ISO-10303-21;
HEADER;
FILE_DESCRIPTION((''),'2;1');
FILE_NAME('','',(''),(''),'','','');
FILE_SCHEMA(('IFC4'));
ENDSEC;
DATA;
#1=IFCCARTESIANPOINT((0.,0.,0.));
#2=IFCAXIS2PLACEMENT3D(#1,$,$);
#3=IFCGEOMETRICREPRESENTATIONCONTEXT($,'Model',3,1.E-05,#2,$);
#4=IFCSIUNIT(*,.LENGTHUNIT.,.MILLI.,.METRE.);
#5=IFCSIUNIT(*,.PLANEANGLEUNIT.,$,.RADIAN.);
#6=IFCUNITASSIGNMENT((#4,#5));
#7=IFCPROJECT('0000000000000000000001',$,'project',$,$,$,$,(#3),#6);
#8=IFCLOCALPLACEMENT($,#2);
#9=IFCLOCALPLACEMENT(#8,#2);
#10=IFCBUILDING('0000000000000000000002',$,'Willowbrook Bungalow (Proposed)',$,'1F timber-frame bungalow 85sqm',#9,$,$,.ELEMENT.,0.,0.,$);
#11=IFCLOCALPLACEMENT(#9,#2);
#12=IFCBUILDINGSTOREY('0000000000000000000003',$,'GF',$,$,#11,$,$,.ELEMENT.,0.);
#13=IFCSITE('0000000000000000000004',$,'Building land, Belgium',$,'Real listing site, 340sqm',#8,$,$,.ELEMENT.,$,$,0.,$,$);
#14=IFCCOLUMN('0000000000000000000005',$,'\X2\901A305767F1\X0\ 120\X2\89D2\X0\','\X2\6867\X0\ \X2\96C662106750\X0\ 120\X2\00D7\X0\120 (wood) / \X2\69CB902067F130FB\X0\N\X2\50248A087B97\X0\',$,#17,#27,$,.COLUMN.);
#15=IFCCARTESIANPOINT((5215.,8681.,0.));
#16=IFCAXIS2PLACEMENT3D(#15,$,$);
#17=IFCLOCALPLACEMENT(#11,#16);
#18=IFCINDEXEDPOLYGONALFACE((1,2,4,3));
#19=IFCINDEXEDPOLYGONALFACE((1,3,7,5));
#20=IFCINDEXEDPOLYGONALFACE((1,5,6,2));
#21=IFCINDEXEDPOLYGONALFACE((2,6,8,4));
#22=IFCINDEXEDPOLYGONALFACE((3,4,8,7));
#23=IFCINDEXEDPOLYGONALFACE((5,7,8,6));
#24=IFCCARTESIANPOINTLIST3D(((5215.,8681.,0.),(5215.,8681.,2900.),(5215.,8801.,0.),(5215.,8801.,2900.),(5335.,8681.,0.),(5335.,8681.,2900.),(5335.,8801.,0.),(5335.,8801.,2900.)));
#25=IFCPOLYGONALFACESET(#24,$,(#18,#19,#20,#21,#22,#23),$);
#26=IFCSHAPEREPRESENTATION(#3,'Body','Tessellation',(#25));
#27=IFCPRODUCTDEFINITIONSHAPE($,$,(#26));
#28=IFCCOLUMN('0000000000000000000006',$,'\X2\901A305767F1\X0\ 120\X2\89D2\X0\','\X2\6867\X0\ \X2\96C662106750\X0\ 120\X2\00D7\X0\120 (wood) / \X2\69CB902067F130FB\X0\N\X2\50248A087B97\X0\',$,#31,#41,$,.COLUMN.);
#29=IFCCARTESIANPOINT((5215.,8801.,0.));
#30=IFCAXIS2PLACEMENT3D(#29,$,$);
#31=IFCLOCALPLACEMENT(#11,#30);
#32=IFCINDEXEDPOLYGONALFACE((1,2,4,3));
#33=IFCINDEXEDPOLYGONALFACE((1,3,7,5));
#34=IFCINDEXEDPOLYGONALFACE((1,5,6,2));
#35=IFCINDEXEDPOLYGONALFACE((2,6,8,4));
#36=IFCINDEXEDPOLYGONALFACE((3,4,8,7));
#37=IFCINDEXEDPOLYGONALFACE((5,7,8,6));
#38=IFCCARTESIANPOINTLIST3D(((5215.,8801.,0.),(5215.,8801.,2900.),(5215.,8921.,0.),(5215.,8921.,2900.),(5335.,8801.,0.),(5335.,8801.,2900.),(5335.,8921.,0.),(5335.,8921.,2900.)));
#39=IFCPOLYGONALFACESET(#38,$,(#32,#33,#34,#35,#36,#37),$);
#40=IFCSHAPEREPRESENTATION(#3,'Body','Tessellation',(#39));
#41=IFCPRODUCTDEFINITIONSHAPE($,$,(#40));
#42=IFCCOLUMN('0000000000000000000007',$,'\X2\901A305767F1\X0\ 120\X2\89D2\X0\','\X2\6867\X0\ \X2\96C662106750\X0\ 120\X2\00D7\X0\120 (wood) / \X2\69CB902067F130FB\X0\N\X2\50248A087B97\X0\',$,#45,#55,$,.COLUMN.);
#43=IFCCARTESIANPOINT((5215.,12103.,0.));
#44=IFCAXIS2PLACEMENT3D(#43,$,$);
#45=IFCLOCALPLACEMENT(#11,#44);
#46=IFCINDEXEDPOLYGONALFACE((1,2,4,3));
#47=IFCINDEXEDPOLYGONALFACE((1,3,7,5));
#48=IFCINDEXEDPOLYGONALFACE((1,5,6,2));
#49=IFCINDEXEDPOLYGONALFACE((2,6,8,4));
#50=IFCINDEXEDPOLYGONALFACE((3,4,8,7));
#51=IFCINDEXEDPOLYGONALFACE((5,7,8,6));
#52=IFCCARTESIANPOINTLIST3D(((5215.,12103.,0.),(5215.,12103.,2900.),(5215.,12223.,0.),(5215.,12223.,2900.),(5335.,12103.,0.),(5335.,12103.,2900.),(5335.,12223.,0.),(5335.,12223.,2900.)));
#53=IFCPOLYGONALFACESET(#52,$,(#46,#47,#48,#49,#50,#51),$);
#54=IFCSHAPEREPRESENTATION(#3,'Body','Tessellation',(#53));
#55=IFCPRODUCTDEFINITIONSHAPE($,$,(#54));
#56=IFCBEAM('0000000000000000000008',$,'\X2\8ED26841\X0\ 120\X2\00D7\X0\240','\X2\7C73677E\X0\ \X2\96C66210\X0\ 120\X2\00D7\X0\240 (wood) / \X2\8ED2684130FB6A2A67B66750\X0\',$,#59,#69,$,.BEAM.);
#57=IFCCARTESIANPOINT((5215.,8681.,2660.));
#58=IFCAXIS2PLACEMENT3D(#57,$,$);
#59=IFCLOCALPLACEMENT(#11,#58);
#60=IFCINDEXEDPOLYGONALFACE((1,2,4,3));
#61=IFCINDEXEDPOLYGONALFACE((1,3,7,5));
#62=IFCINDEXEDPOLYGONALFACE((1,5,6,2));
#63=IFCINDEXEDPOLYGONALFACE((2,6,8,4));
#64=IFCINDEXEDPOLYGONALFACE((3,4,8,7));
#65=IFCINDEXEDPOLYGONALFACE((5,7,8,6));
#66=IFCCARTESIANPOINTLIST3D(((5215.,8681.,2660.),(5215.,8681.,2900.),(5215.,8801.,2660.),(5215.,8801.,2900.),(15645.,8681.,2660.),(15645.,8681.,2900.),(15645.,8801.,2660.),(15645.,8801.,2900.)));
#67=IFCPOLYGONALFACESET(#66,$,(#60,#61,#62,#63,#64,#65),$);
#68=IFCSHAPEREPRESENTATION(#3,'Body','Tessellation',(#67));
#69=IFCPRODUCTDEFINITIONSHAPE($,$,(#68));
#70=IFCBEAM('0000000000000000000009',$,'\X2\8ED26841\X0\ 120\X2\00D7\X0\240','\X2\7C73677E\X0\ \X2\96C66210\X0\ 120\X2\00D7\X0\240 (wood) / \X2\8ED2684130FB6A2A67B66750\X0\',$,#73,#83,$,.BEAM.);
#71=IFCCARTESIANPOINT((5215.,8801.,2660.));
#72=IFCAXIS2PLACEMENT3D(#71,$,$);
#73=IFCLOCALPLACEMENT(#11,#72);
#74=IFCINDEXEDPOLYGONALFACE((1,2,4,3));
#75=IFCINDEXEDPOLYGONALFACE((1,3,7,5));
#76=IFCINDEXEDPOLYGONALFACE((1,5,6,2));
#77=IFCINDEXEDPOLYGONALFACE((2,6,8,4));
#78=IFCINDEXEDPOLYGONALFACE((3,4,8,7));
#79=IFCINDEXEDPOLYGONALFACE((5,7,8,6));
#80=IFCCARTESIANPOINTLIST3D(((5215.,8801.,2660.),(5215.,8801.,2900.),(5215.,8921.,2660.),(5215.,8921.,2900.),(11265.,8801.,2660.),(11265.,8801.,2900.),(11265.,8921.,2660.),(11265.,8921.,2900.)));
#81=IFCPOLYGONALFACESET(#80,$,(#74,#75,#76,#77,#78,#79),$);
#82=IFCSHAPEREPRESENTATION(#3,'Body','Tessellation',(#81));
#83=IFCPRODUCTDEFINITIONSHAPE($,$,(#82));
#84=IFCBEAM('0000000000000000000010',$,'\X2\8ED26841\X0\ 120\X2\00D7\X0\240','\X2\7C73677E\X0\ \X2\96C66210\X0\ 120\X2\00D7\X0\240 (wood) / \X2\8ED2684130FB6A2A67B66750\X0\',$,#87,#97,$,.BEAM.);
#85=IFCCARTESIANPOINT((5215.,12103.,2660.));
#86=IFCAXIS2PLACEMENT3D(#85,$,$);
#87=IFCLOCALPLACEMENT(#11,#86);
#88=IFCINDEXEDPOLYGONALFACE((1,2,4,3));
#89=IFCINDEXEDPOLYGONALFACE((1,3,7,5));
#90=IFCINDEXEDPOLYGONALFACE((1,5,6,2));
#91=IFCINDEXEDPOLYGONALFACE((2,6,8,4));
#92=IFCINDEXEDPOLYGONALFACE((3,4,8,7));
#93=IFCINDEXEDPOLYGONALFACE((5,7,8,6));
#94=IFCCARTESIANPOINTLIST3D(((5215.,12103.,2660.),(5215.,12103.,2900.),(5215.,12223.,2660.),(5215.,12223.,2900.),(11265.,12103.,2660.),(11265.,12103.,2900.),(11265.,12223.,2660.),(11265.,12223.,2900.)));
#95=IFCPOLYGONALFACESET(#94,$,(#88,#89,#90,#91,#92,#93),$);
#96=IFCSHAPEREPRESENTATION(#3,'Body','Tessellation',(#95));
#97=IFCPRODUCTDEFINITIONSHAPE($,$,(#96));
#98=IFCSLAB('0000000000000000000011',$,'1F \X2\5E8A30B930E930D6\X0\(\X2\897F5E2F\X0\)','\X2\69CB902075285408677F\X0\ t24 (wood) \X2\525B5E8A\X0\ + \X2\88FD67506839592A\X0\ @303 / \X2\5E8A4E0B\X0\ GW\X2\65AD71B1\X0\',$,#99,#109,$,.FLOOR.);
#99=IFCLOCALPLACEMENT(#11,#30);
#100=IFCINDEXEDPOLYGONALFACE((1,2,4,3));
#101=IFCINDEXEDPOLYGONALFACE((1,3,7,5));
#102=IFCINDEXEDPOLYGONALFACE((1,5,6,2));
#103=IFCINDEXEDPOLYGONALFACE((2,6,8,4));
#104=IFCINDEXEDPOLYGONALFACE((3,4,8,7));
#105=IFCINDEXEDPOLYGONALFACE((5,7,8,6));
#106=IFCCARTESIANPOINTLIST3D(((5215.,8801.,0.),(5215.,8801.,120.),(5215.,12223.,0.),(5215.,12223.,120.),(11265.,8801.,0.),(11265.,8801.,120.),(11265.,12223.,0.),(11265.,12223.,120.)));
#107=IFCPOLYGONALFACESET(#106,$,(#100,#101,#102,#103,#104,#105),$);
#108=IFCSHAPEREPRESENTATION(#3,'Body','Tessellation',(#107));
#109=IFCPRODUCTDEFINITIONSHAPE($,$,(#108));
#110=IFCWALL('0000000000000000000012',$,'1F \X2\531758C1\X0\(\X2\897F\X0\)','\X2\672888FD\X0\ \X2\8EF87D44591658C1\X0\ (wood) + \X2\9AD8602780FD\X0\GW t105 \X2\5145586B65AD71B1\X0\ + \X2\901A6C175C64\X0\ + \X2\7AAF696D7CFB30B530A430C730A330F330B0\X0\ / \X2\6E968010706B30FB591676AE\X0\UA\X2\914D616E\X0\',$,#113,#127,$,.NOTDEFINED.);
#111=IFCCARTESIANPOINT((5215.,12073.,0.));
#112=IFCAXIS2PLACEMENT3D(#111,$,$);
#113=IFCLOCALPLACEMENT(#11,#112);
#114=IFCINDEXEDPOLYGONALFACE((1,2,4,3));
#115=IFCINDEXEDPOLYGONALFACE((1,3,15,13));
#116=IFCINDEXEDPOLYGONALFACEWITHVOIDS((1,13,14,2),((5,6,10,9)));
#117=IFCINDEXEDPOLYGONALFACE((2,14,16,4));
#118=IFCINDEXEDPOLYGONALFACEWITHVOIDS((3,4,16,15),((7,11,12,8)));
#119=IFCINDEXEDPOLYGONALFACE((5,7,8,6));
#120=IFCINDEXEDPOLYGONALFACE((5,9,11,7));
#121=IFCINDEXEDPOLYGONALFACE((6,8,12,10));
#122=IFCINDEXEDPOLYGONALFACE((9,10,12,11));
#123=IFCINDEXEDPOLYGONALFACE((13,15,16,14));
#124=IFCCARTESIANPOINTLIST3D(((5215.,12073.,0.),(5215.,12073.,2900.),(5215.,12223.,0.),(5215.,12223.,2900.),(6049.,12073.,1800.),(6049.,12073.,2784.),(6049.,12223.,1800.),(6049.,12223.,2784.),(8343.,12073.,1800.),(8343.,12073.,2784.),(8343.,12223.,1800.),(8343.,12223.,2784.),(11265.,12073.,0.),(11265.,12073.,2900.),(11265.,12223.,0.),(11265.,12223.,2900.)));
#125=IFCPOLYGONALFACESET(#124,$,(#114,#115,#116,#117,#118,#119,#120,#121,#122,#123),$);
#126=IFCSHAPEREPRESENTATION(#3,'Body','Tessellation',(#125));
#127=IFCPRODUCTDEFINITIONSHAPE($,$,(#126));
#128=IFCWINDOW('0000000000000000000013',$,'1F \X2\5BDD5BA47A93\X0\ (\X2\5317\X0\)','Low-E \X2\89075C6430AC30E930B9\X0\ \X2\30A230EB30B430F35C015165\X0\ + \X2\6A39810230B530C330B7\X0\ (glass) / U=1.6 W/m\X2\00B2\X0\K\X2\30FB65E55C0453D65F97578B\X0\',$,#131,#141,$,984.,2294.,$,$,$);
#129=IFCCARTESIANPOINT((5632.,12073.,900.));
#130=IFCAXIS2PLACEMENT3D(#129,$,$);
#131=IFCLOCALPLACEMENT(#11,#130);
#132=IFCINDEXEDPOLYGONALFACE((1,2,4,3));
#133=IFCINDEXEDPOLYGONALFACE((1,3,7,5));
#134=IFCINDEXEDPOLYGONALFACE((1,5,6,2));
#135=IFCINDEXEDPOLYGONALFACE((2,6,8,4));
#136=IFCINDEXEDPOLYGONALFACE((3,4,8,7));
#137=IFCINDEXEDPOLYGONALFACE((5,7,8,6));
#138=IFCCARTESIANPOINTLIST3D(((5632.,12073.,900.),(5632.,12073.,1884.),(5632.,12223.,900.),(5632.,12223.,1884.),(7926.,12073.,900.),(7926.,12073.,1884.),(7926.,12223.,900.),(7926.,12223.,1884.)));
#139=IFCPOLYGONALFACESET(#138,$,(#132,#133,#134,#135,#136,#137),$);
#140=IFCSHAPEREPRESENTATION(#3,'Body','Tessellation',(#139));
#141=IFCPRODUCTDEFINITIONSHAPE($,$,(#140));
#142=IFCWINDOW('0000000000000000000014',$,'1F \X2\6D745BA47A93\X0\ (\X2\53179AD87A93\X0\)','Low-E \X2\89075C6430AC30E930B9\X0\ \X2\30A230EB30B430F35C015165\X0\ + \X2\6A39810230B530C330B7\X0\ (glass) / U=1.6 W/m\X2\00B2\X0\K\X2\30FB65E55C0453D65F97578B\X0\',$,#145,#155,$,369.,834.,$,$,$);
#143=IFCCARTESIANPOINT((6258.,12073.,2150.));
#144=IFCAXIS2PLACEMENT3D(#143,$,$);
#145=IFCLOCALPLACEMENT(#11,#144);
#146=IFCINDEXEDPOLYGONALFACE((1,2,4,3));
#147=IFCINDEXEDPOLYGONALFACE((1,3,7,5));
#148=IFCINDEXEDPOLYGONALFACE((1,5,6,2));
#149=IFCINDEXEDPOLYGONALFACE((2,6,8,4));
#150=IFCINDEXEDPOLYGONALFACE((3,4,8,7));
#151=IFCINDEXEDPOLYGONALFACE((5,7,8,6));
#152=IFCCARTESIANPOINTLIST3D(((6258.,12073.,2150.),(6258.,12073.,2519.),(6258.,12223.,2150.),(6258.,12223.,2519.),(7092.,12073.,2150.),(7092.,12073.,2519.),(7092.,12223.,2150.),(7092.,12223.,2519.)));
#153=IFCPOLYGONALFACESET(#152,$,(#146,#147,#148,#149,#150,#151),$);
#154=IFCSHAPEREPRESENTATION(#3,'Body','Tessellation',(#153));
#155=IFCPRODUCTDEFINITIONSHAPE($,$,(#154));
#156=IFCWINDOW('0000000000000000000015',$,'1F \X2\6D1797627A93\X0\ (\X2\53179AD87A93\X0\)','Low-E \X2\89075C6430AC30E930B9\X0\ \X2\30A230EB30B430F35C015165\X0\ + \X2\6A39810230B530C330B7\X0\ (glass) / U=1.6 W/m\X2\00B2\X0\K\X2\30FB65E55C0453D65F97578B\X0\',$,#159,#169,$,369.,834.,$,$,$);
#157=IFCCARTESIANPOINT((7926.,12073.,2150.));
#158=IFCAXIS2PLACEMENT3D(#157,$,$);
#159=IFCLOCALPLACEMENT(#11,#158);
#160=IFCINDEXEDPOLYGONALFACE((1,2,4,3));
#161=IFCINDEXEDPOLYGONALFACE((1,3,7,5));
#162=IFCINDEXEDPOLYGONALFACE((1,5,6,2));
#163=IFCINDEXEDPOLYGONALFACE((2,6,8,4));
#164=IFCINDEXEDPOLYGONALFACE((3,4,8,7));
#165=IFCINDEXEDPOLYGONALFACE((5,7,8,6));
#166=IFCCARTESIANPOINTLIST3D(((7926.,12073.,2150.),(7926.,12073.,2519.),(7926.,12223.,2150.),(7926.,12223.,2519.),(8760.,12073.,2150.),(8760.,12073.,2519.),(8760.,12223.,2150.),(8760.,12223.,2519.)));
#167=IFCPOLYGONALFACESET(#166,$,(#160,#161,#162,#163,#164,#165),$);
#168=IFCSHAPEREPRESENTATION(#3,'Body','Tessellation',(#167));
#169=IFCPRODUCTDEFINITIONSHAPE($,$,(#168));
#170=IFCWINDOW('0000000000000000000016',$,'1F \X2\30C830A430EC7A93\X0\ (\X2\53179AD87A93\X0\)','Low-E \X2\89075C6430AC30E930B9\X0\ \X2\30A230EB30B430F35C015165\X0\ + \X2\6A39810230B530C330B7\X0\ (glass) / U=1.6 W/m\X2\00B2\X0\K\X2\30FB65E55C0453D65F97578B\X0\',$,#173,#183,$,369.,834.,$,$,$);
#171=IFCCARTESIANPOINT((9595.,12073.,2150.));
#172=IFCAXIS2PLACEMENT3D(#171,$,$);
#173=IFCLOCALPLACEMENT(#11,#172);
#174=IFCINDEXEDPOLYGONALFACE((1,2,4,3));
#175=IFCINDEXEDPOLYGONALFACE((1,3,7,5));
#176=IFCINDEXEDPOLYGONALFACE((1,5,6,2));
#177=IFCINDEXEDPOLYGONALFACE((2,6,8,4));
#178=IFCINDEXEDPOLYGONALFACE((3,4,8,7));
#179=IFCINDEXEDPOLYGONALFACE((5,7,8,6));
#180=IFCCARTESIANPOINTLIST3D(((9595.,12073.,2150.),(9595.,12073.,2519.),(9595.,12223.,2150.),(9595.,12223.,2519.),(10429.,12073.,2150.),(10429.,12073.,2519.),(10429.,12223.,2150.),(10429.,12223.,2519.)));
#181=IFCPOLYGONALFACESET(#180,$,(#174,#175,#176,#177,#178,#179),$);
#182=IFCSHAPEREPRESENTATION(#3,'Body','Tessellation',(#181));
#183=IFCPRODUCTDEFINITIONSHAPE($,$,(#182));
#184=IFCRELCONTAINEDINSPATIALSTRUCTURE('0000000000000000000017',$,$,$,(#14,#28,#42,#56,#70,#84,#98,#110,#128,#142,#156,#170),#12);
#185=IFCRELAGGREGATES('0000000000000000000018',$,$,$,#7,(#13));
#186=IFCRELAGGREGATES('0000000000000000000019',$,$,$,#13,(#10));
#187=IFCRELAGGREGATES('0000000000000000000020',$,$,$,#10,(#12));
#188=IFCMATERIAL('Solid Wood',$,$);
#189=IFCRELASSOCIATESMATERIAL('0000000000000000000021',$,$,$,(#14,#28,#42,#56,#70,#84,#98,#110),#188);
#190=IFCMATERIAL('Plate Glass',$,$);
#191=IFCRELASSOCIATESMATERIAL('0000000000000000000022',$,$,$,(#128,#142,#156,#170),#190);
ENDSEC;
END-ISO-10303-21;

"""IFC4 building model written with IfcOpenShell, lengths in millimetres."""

from ifc_helpers import new_model, si_unit, frame, frame_2d, origin, place, context, project, spatial, rectangle, extrude, material, element, fill, save


model = new_model("IFC4")

# Units and contexts
model_context = context("Model", 3, precision=1e-05, world=origin())
ifc_project = project(units=[si_unit("LENGTHUNIT", "METRE", prefix="MILLI"), si_unit("PLANEANGLEUNIT", "RADIAN")], contexts=[model_context])

# Site, building, storey
site_placement = place(None, origin())
site = spatial("IfcSite", under=ifc_project, at=site_placement, Name="Building land, Belgium", ObjectType="Real listing site, 340sqm", CompositionType="ELEMENT", RefElevation=0.0)
building_placement = place(site_placement, origin())
building = spatial("IfcBuilding", under=site, at=building_placement, Name="Willowbrook Bungalow (Proposed)", ObjectType="1F timber-frame bungalow 85sqm", CompositionType="ELEMENT", ElevationOfRefHeight=0.0, ElevationOfTerrain=0.0)
storey_placement = place(building_placement, origin())
storey = spatial("IfcBuildingStorey", under=building, at=storey_placement, Name="GF", CompositionType="ELEMENT", Elevation=0.0)

# Columns
ifc_material_1 = material(Name="Solid Wood")
column_1_placement = place(storey_placement, frame((5215.0, 8681.0, 0.0)))
element("IfcColumn", 1, at=column_1_placement, inside=storey, material=ifc_material_1, Name="通し柱 120角", Description="桧 集成材 120×120 (wood) / 構造柱・N値計算", PredefinedType="COLUMN", context=model_context, shape_type="SweptSolid", body=[
    extrude(rectangle(XDim=120.0, YDim=120.0, at=frame_2d((60.0, 60.0))), frame((5215.0, 8681.0, 0.0)), (0.0, 0.0, 1.0), 2900.0),
])
column_2_placement = place(storey_placement, frame((5215.0, 8801.0, 0.0)))
element("IfcColumn", 2, at=column_2_placement, inside=storey, material=ifc_material_1, Name="通し柱 120角", Description="桧 集成材 120×120 (wood) / 構造柱・N値計算", PredefinedType="COLUMN", context=model_context, shape_type="SweptSolid", body=[
    extrude(rectangle(XDim=120.0, YDim=120.0, at=frame_2d((60.0, 60.0))), frame((5215.0, 8801.0, 0.0)), (0.0, 0.0, 1.0), 2900.0),
])
column_3_placement = place(storey_placement, frame((5215.0, 12103.0, 0.0)))
element("IfcColumn", 3, at=column_3_placement, inside=storey, material=ifc_material_1, Name="通し柱 120角", Description="桧 集成材 120×120 (wood) / 構造柱・N値計算", PredefinedType="COLUMN", context=model_context, shape_type="SweptSolid", body=[
    extrude(rectangle(XDim=120.0, YDim=120.0, at=frame_2d((60.0, 60.0))), frame((5215.0, 12103.0, 0.0)), (0.0, 0.0, 1.0), 2900.0),
])

# Beams
beam_1_placement = place(storey_placement, frame((5215.0, 8681.0, 2660.0)))
element("IfcBeam", 4, at=beam_1_placement, inside=storey, material=ifc_material_1, Name="軒桁 120×240", Description="米松 集成 120×240 (wood) / 軒桁・横架材", PredefinedType="BEAM", context=model_context, shape_type="SweptSolid", body=[
    extrude(rectangle(XDim=10430.0, YDim=120.0, at=frame_2d((5215.0, 60.0))), frame((5215.0, 8681.0, 2660.0)), (0.0, 0.0, 1.0), 240.0),
])
beam_2_placement = place(storey_placement, frame((5215.0, 8801.0, 2660.0)))
element("IfcBeam", 5, at=beam_2_placement, inside=storey, material=ifc_material_1, Name="軒桁 120×240", Description="米松 集成 120×240 (wood) / 軒桁・横架材", PredefinedType="BEAM", context=model_context, shape_type="SweptSolid", body=[
    extrude(rectangle(XDim=6050.0, YDim=120.0, at=frame_2d((3025.0, 60.0))), frame((5215.0, 8801.0, 2660.0)), (0.0, 0.0, 1.0), 240.0),
])
beam_3_placement = place(storey_placement, frame((5215.0, 12103.0, 2660.0)))
element("IfcBeam", 6, at=beam_3_placement, inside=storey, material=ifc_material_1, Name="軒桁 120×240", Description="米松 集成 120×240 (wood) / 軒桁・横架材", PredefinedType="BEAM", context=model_context, shape_type="SweptSolid", body=[
    extrude(rectangle(XDim=6050.0, YDim=120.0, at=frame_2d((3025.0, 60.0))), frame((5215.0, 12103.0, 2660.0)), (0.0, 0.0, 1.0), 240.0),
])

# Slab
slab_placement = place(storey_placement, frame((5215.0, 8801.0, 0.0)))
element("IfcSlab", 7, at=slab_placement, inside=storey, material=ifc_material_1, Name="1F 床スラブ(西帯)", Description="構造用合板 t24 (wood) 剛床 + 製材根太 @303 / 床下 GW断熱", PredefinedType="FLOOR", context=model_context, shape_type="SweptSolid", body=[
    extrude(rectangle(XDim=6050.0, YDim=3422.0, at=frame_2d((3025.0, 1711.0))), frame((5215.0, 8801.0, 0.0)), (0.0, 0.0, 1.0), 120.0),
])

# Wall, openings, windows
wall_1_placement = place(storey_placement, frame((5215.0, 12073.0, 0.0)))
wall_1 = element("IfcWall", 8, at=wall_1_placement, inside=storey, material=ifc_material_1, Name="1F 北壁(西)", Description="木製 軸組外壁 (wood) + 高性能GW t105 充填断熱 + 通気層 + 窯業系サイディング / 準耐火・外皮UA配慮", PredefinedType="NOTDEFINED", context=model_context, shape_type="SweptSolid", body=[
    extrude(rectangle(XDim=6050.0, YDim=150.0, at=frame_2d((3025.0, 75.0))), frame((5215.0, 12073.0, 0.0)), (0.0, 0.0, 1.0), 2900.0),
])
opening_1_placement = place(storey_placement, frame((5632.0, 12073.0, 900.0)))
opening_1 = element("IfcOpeningElement", 9, at=opening_1_placement, cuts=wall_1, PredefinedType="NOTDEFINED", context=model_context, shape_type="SweptSolid", body=[
    extrude(rectangle(XDim=2294.0, YDim=150.0, at=frame_2d((1147.0, 75.0))), frame((5632.0, 12073.0, 900.0)), (0.0, 0.0, 1.0), 984.0),
])
opening_2_placement = place(storey_placement, frame((6258.0, 12073.0, 2150.0)))
opening_2 = element("IfcOpeningElement", 10, at=opening_2_placement, cuts=wall_1, PredefinedType="NOTDEFINED", context=model_context, shape_type="SweptSolid", body=[
    extrude(rectangle(XDim=834.0, YDim=150.0, at=frame_2d((417.0, 75.0))), frame((6258.0, 12073.0, 2150.0)), (0.0, 0.0, 1.0), 369.0),
])
opening_3_placement = place(storey_placement, frame((7926.0, 12073.0, 2150.0)))
opening_3 = element("IfcOpeningElement", 11, at=opening_3_placement, cuts=wall_1, PredefinedType="NOTDEFINED", context=model_context, shape_type="SweptSolid", body=[
    extrude(rectangle(XDim=834.0, YDim=150.0, at=frame_2d((417.0, 75.0))), frame((7926.0, 12073.0, 2150.0)), (0.0, 0.0, 1.0), 369.0),
])
opening_4_placement = place(storey_placement, frame((9595.0, 12073.0, 2150.0)))
opening_4 = element("IfcOpeningElement", 12, at=opening_4_placement, cuts=wall_1, PredefinedType="NOTDEFINED", context=model_context, shape_type="SweptSolid", body=[
    extrude(rectangle(XDim=834.0, YDim=150.0, at=frame_2d((417.0, 75.0))), frame((9595.0, 12073.0, 2150.0)), (0.0, 0.0, 1.0), 369.0),
])
ifc_material_2 = material(Name="Plate Glass")
window_1_placement = place(storey_placement, frame((5632.0, 12073.0, 900.0)))
window_1 = element("IfcWindow", 13, at=window_1_placement, inside=storey, material=ifc_material_2, Name="1F 寝室窓 (北)", Description="Low-E 複層ガラス アルゴン封入 + 樹脂サッシ (glass) / U=1.6 W/m²K・日射取得型", OverallHeight=984.0, OverallWidth=2294.0, context=model_context, shape_type="SweptSolid", body=[
    extrude(rectangle(XDim=2294.0, YDim=150.0, at=frame_2d((1147.0, 75.0))), frame((5632.0, 12073.0, 900.0)), (0.0, 0.0, 1.0), 984.0),
])
fill(opening_1, window_1)
window_2_placement = place(storey_placement, frame((6258.0, 12073.0, 2150.0)))
window_2 = element("IfcWindow", 14, at=window_2_placement, inside=storey, material=ifc_material_2, Name="1F 浴室窓 (北高窓)", Description="Low-E 複層ガラス アルゴン封入 + 樹脂サッシ (glass) / U=1.6 W/m²K・日射取得型", OverallHeight=369.0, OverallWidth=834.0, context=model_context, shape_type="SweptSolid", body=[
    extrude(rectangle(XDim=834.0, YDim=150.0, at=frame_2d((417.0, 75.0))), frame((6258.0, 12073.0, 2150.0)), (0.0, 0.0, 1.0), 369.0),
])
fill(opening_2, window_2)
window_3_placement = place(storey_placement, frame((7926.0, 12073.0, 2150.0)))
window_3 = element("IfcWindow", 15, at=window_3_placement, inside=storey, material=ifc_material_2, Name="1F 洗面窓 (北高窓)", Description="Low-E 複層ガラス アルゴン封入 + 樹脂サッシ (glass) / U=1.6 W/m²K・日射取得型", OverallHeight=369.0, OverallWidth=834.0, context=model_context, shape_type="SweptSolid", body=[
    extrude(rectangle(XDim=834.0, YDim=150.0, at=frame_2d((417.0, 75.0))), frame((7926.0, 12073.0, 2150.0)), (0.0, 0.0, 1.0), 369.0),
])
fill(opening_3, window_3)
window_4_placement = place(storey_placement, frame((9595.0, 12073.0, 2150.0)))
window_4 = element("IfcWindow", 16, at=window_4_placement, inside=storey, material=ifc_material_2, Name="1F トイレ窓 (北高窓)", Description="Low-E 複層ガラス アルゴン封入 + 樹脂サッシ (glass) / U=1.6 W/m²K・日射取得型", OverallHeight=369.0, OverallWidth=834.0, context=model_context, shape_type="SweptSolid", body=[
    extrude(rectangle(XDim=834.0, YDim=150.0, at=frame_2d((417.0, 75.0))), frame((9595.0, 12073.0, 2150.0)), (0.0, 0.0, 1.0), 369.0),
])
fill(opening_4, window_4)

save(model, "model.ifc")
